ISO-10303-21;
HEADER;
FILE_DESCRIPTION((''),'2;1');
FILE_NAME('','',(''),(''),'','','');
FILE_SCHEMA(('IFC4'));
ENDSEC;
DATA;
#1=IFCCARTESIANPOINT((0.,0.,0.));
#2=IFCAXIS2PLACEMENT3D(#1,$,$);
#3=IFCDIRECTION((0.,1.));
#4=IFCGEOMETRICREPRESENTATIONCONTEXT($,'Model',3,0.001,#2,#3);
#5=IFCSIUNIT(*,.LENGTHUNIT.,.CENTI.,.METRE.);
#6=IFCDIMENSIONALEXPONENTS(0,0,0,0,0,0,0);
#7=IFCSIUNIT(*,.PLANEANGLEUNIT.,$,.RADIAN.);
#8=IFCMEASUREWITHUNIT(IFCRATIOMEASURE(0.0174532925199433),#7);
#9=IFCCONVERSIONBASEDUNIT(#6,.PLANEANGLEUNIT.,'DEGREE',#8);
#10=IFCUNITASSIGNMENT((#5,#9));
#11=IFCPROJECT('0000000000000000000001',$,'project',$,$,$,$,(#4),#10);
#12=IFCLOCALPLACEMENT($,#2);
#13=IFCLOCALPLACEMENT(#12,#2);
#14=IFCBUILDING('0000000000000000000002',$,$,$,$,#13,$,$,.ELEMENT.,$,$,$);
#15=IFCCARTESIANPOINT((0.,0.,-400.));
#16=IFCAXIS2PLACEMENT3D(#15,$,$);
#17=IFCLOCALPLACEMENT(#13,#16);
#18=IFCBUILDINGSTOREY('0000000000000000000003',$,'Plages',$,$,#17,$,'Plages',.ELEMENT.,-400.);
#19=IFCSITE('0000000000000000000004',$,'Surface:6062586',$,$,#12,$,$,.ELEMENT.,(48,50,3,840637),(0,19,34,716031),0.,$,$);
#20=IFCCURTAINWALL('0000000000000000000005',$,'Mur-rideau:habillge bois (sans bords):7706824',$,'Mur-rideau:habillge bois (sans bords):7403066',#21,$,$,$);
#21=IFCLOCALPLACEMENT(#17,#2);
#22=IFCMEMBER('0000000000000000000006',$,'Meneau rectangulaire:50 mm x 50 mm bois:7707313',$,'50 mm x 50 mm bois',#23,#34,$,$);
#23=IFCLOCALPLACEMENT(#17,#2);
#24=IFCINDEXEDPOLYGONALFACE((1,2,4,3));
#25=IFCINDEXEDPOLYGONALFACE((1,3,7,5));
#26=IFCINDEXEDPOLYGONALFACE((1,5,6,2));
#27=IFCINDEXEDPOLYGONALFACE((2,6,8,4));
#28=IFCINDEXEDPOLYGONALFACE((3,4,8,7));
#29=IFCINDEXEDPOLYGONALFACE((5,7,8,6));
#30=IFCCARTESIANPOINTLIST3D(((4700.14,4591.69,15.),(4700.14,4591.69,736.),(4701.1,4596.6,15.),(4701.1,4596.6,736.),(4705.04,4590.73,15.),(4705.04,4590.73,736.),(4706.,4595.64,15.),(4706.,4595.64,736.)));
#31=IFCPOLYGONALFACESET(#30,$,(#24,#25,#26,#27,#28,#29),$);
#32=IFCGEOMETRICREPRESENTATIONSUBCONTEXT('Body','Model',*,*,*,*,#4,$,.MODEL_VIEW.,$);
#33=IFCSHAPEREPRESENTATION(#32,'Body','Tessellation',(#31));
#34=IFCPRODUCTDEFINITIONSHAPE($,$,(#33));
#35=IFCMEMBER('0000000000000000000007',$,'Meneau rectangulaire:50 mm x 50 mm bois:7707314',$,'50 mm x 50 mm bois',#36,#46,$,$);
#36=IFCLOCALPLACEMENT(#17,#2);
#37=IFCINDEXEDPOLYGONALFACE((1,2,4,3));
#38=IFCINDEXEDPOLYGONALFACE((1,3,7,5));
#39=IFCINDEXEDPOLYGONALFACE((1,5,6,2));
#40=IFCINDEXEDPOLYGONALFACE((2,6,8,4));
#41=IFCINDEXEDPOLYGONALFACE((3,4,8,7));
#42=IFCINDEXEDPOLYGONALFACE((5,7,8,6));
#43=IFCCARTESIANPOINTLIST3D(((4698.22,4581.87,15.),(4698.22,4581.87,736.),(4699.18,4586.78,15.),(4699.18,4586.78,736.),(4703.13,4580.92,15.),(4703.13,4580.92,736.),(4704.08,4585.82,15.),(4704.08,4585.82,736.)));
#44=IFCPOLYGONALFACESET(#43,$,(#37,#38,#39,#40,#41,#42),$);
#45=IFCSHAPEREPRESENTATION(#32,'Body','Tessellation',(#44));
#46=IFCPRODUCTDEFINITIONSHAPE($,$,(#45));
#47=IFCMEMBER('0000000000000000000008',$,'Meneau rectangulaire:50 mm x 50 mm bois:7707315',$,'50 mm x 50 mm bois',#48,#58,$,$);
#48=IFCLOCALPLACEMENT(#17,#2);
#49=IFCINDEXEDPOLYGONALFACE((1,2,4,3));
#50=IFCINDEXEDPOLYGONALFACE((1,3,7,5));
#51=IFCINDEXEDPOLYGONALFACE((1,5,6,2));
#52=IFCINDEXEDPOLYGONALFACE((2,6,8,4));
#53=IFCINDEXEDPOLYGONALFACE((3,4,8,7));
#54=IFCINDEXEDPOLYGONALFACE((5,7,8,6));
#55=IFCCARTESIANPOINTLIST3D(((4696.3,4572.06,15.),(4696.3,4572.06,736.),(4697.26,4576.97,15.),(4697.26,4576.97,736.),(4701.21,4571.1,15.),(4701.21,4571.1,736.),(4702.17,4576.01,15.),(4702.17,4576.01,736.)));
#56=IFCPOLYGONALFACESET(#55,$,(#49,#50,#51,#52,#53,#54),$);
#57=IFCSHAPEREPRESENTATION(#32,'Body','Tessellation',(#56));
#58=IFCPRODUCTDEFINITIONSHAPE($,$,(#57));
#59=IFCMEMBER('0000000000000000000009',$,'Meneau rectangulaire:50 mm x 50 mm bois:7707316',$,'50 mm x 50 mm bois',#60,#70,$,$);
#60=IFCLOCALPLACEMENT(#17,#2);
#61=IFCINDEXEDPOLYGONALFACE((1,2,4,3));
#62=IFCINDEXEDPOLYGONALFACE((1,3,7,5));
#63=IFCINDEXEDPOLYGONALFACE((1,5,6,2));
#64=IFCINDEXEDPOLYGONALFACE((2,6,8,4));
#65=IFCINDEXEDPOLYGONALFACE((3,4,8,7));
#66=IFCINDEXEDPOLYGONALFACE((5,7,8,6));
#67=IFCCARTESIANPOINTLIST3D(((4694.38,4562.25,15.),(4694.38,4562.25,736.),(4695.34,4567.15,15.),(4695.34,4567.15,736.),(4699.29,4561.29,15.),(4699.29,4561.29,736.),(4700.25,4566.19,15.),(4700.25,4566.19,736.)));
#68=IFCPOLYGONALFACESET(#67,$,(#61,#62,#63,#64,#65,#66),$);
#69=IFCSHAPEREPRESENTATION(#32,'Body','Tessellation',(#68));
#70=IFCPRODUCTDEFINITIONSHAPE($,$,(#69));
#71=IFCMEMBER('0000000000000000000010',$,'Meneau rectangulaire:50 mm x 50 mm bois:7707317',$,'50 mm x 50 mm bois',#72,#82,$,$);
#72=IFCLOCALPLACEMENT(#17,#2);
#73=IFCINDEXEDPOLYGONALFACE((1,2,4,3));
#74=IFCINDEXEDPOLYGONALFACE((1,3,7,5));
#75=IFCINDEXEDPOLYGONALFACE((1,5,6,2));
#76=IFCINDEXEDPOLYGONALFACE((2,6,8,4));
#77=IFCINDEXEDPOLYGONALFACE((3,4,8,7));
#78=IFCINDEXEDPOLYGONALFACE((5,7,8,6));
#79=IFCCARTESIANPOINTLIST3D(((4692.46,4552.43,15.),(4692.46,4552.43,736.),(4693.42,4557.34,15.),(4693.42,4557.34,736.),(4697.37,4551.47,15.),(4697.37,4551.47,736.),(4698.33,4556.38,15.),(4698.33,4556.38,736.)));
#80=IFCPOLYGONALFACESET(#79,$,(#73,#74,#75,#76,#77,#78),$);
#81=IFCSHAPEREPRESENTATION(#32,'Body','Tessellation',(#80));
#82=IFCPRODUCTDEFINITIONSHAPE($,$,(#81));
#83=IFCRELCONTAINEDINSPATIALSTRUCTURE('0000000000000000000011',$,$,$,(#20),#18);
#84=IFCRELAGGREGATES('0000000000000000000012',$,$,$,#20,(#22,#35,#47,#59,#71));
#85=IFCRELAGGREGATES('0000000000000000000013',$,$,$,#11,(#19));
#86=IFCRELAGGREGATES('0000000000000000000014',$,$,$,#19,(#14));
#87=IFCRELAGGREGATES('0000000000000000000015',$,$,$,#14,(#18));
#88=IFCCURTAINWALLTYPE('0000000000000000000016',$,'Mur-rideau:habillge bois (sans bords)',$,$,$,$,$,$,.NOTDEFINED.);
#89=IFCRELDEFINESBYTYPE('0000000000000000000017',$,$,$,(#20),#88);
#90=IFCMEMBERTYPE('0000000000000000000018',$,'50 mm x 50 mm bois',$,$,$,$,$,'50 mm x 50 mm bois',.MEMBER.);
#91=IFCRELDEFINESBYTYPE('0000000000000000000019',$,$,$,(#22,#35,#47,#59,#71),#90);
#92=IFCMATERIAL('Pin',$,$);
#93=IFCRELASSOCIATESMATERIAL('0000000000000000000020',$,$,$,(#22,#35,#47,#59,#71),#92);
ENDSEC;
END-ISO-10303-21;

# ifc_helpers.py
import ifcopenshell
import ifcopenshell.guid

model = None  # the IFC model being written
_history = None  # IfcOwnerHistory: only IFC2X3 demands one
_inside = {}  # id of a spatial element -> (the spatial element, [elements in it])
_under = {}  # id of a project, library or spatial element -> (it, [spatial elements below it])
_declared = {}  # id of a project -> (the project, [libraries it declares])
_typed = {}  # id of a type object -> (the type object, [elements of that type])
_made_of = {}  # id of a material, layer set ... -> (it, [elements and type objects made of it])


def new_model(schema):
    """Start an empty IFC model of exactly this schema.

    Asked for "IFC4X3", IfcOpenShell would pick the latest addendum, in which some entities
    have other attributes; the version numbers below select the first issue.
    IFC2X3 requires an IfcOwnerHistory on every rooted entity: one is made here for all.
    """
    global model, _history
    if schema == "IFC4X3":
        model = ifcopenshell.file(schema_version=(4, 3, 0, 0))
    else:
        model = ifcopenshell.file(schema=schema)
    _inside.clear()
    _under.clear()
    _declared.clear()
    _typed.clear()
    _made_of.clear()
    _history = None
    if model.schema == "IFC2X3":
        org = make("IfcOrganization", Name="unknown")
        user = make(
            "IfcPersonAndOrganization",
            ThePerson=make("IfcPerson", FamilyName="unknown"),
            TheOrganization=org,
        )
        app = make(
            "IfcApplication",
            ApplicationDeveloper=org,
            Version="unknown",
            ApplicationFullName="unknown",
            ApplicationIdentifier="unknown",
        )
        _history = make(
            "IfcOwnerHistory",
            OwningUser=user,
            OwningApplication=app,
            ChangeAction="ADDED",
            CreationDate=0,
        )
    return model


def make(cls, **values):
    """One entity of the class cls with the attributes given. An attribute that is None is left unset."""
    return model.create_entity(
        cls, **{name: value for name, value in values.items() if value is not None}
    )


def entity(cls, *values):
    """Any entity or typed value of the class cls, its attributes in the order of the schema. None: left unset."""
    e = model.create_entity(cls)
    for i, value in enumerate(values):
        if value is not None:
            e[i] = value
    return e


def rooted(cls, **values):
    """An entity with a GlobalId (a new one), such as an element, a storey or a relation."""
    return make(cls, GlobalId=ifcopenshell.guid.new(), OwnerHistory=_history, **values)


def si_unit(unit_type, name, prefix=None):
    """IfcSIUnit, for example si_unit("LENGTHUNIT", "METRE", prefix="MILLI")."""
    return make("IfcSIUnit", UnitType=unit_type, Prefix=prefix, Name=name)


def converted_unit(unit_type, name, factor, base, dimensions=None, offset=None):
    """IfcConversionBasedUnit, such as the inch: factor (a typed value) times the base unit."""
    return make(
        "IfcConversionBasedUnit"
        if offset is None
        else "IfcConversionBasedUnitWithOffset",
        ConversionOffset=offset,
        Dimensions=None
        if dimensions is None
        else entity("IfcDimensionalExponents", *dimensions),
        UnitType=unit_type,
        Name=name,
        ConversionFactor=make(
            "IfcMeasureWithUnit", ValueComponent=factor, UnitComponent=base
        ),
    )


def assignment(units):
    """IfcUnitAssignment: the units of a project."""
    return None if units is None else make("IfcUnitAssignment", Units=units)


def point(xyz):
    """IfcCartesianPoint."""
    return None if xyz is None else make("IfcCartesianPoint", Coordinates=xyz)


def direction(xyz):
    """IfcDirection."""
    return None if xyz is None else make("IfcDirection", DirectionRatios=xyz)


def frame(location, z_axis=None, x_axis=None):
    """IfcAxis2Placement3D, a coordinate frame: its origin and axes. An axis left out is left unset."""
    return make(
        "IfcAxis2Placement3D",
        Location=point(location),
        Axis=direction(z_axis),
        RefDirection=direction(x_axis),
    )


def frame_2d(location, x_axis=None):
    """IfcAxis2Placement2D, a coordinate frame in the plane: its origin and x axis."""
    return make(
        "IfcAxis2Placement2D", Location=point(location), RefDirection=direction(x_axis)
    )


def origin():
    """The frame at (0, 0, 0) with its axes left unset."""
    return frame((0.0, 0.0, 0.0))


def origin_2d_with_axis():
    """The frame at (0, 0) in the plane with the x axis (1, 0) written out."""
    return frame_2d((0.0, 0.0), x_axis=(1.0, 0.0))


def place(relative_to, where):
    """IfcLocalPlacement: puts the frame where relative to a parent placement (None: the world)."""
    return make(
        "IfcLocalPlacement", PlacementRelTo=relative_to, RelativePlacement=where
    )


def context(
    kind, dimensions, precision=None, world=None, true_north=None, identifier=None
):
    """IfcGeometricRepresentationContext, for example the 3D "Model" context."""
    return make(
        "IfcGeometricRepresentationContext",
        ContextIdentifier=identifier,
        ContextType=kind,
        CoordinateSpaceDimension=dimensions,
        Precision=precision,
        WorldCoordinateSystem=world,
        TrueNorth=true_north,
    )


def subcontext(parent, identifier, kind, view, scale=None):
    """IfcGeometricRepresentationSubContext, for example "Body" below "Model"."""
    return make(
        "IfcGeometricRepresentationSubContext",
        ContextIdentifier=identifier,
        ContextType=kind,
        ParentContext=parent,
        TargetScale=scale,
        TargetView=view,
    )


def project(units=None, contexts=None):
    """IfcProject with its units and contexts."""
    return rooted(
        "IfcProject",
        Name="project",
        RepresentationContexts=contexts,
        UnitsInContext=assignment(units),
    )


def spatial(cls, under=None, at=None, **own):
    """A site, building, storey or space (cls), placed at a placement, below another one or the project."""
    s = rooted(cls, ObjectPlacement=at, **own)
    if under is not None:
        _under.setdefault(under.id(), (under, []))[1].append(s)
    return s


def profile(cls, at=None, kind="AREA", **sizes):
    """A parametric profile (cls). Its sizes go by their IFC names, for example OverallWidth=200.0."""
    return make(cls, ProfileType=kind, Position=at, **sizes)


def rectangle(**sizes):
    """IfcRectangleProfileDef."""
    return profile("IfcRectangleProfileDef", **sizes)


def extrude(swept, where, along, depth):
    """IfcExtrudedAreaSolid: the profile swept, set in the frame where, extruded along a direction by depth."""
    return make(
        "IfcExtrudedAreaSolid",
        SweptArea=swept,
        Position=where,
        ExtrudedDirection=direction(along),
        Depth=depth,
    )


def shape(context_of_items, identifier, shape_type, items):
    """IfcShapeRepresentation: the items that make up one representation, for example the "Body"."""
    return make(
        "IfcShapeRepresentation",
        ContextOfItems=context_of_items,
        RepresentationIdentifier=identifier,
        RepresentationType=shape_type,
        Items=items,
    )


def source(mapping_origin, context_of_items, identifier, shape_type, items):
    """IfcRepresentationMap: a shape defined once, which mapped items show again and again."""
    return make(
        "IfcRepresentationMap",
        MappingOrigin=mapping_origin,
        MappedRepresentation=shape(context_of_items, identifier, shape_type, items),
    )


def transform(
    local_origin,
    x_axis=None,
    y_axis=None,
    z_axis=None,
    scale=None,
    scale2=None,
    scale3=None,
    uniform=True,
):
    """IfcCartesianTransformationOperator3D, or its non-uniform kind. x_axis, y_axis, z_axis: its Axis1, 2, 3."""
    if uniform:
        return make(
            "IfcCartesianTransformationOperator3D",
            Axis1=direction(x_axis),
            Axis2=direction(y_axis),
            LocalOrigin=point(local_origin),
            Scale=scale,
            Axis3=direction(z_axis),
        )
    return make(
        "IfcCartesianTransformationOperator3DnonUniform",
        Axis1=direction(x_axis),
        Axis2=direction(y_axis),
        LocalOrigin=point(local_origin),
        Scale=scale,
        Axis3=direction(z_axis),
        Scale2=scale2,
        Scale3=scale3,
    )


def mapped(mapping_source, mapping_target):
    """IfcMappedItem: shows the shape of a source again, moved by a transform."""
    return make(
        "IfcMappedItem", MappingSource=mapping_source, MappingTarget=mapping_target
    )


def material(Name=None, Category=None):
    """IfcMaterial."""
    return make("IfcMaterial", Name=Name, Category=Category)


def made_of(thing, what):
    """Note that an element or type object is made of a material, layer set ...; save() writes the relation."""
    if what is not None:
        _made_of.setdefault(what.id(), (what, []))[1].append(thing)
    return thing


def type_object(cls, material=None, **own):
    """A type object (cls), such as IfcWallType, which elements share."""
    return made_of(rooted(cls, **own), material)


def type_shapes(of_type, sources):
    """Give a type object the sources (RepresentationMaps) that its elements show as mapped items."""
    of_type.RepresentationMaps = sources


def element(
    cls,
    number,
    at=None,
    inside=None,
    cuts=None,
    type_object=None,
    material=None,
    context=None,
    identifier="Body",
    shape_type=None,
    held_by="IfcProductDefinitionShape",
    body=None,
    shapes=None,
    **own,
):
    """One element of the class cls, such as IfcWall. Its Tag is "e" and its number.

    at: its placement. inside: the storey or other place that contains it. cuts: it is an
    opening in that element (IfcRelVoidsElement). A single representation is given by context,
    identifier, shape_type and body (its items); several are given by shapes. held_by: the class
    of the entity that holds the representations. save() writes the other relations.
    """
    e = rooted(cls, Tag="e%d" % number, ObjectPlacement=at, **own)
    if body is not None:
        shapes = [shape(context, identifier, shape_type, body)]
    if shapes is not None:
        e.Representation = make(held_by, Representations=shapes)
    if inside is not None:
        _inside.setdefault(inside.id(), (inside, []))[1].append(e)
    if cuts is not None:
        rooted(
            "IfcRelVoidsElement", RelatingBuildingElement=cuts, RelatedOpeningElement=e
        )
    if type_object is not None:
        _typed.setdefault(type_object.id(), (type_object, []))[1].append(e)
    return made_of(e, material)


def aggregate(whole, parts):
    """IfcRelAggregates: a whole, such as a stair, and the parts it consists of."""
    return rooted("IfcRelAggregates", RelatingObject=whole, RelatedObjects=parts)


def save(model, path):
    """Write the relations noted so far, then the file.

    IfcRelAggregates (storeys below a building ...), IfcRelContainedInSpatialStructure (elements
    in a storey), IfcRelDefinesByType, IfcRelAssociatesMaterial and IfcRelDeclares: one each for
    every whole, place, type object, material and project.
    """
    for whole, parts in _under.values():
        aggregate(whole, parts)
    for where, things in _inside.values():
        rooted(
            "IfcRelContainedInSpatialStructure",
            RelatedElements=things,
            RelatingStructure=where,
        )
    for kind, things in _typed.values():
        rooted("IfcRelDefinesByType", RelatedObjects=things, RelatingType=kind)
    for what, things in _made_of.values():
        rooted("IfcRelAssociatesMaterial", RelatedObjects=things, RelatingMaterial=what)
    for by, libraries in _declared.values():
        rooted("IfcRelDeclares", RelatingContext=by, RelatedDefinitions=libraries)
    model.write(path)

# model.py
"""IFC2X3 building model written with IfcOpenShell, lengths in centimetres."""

from ifc_helpers import new_model, entity, si_unit, converted_unit, direction, frame, origin, origin_2d_with_axis, place, context, subcontext, project, spatial, rectangle, extrude, source, transform, mapped, material, type_object, type_shapes, element, aggregate, save


model = new_model("IFC2X3")

# Units and contexts
model_context = context("Model", 3, precision=0.001, world=origin(), true_north=direction((0.0, 1.0)))
body_context = subcontext(model_context, "Body", "Model", "MODEL_VIEW")
ifc_project = project(units=[si_unit("LENGTHUNIT", "METRE", prefix="CENTI"), converted_unit("PLANEANGLEUNIT", "DEGREE", entity("IfcRatioMeasure", 0.0174532925199433), si_unit("PLANEANGLEUNIT", "RADIAN"), dimensions=[0, 0, 0, 0, 0, 0, 0])], contexts=[model_context])

# Site, building, storey
site_placement = place(None, origin())
site = spatial("IfcSite", under=ifc_project, at=site_placement, Name="Surface:6062586", CompositionType="ELEMENT", RefLatitude=(48, 50, 3, 840637), RefLongitude=(0, 19, 34, 716031), RefElevation=0.0)
building_placement = place(site_placement, origin())
building = spatial("IfcBuilding", under=site, at=building_placement, CompositionType="ELEMENT")
storey_placement = place(building_placement, frame((0.0, 0.0, -400.0)))
storey = spatial("IfcBuildingStorey", under=building, at=storey_placement, Name="Plages", LongName="Plages", CompositionType="ELEMENT", Elevation=-400.0)

# Curtain wall, members
curtain_wall_type = type_object("IfcCurtainWallType", Name="Mur-rideau:habillge bois (sans bords)", PredefinedType="NOTDEFINED")
curtain_wall_placement = place(storey_placement, frame((0.0, 0.0, 400.0)))
curtain_wall = element("IfcCurtainWall", 1, at=curtain_wall_placement, inside=storey, type_object=curtain_wall_type, Name="Mur-rideau:habillge bois (sans bords):7706824", ObjectType="Mur-rideau:habillge bois (sans bords):7403066")
ifc_material = material(Name="Pin")
member_type = type_object("IfcMemberType", Name="50 mm x 50 mm bois", ElementType="50 mm x 50 mm bois", PredefinedType="MEMBER")
shared_shape = source(origin(), body_context, "Body", "SweptSolid", [
    extrude(rectangle(XDim=5.0, YDim=5.0, at=origin_2d_with_axis()), frame((0.0, 0.0, -721.0), z_axis=(0.0, 0.0, 1.0), x_axis=(0.0, -1.0, 0.0)), (0.0, 0.0, 1.0), 721.0),
])
type_shapes(member_type, [shared_shape])
placement = place(building_placement, frame((0.0, 0.0, 336.0)))
member_1_placement = place(placement, frame((4703.07, 4593.66, -721.0), z_axis=(0.0, 0.0, -1.0), x_axis=(0.191861, 0.981422, 0.0)))
member_1 = element("IfcMember", 2, at=member_1_placement, type_object=member_type, material=ifc_material, Name="Meneau rectangulaire:50 mm x 50 mm bois:7707313", ObjectType="50 mm x 50 mm bois", context=body_context, shape_type="MappedRepresentation", body=[
    mapped(shared_shape, transform((0.0, 0.0, 0.0), scale=1.0)),
])
member_2_placement = place(placement, frame((4701.15, 4583.85, -721.0), z_axis=(0.0, 0.0, -1.0), x_axis=(0.191861, 0.981422, 0.0)))
member_2 = element("IfcMember", 3, at=member_2_placement, type_object=member_type, material=ifc_material, Name="Meneau rectangulaire:50 mm x 50 mm bois:7707314", ObjectType="50 mm x 50 mm bois", context=body_context, shape_type="MappedRepresentation", body=[
    mapped(shared_shape, transform((0.0, 0.0, 0.0), scale=1.0)),
])
member_3_placement = place(placement, frame((4699.23, 4574.03, -721.0), z_axis=(0.0, 0.0, -1.0), x_axis=(0.191861, 0.981422, 0.0)))
member_3 = element("IfcMember", 4, at=member_3_placement, type_object=member_type, material=ifc_material, Name="Meneau rectangulaire:50 mm x 50 mm bois:7707315", ObjectType="50 mm x 50 mm bois", context=body_context, shape_type="MappedRepresentation", body=[
    mapped(shared_shape, transform((0.0, 0.0, 0.0), scale=1.0)),
])
member_4_placement = place(placement, frame((4697.31, 4564.22, -721.0), z_axis=(0.0, 0.0, -1.0), x_axis=(0.191861, 0.981422, 0.0)))
member_4 = element("IfcMember", 5, at=member_4_placement, type_object=member_type, material=ifc_material, Name="Meneau rectangulaire:50 mm x 50 mm bois:7707316", ObjectType="50 mm x 50 mm bois", context=body_context, shape_type="MappedRepresentation", body=[
    mapped(shared_shape, transform((0.0, 0.0, 0.0), scale=1.0)),
])
member_5_placement = place(placement, frame((4695.4, 4554.41, -721.0), z_axis=(0.0, 0.0, -1.0), x_axis=(0.191861, 0.981422, 0.0)))
member_5 = element("IfcMember", 6, at=member_5_placement, type_object=member_type, material=ifc_material, Name="Meneau rectangulaire:50 mm x 50 mm bois:7707317", ObjectType="50 mm x 50 mm bois", context=body_context, shape_type="MappedRepresentation", body=[
    mapped(shared_shape, transform((0.0, 0.0, 0.0), scale=1.0)),
])
aggregate(curtain_wall, [member_1, member_2, member_3, member_4, member_5])

save(model, "model.ifc")
